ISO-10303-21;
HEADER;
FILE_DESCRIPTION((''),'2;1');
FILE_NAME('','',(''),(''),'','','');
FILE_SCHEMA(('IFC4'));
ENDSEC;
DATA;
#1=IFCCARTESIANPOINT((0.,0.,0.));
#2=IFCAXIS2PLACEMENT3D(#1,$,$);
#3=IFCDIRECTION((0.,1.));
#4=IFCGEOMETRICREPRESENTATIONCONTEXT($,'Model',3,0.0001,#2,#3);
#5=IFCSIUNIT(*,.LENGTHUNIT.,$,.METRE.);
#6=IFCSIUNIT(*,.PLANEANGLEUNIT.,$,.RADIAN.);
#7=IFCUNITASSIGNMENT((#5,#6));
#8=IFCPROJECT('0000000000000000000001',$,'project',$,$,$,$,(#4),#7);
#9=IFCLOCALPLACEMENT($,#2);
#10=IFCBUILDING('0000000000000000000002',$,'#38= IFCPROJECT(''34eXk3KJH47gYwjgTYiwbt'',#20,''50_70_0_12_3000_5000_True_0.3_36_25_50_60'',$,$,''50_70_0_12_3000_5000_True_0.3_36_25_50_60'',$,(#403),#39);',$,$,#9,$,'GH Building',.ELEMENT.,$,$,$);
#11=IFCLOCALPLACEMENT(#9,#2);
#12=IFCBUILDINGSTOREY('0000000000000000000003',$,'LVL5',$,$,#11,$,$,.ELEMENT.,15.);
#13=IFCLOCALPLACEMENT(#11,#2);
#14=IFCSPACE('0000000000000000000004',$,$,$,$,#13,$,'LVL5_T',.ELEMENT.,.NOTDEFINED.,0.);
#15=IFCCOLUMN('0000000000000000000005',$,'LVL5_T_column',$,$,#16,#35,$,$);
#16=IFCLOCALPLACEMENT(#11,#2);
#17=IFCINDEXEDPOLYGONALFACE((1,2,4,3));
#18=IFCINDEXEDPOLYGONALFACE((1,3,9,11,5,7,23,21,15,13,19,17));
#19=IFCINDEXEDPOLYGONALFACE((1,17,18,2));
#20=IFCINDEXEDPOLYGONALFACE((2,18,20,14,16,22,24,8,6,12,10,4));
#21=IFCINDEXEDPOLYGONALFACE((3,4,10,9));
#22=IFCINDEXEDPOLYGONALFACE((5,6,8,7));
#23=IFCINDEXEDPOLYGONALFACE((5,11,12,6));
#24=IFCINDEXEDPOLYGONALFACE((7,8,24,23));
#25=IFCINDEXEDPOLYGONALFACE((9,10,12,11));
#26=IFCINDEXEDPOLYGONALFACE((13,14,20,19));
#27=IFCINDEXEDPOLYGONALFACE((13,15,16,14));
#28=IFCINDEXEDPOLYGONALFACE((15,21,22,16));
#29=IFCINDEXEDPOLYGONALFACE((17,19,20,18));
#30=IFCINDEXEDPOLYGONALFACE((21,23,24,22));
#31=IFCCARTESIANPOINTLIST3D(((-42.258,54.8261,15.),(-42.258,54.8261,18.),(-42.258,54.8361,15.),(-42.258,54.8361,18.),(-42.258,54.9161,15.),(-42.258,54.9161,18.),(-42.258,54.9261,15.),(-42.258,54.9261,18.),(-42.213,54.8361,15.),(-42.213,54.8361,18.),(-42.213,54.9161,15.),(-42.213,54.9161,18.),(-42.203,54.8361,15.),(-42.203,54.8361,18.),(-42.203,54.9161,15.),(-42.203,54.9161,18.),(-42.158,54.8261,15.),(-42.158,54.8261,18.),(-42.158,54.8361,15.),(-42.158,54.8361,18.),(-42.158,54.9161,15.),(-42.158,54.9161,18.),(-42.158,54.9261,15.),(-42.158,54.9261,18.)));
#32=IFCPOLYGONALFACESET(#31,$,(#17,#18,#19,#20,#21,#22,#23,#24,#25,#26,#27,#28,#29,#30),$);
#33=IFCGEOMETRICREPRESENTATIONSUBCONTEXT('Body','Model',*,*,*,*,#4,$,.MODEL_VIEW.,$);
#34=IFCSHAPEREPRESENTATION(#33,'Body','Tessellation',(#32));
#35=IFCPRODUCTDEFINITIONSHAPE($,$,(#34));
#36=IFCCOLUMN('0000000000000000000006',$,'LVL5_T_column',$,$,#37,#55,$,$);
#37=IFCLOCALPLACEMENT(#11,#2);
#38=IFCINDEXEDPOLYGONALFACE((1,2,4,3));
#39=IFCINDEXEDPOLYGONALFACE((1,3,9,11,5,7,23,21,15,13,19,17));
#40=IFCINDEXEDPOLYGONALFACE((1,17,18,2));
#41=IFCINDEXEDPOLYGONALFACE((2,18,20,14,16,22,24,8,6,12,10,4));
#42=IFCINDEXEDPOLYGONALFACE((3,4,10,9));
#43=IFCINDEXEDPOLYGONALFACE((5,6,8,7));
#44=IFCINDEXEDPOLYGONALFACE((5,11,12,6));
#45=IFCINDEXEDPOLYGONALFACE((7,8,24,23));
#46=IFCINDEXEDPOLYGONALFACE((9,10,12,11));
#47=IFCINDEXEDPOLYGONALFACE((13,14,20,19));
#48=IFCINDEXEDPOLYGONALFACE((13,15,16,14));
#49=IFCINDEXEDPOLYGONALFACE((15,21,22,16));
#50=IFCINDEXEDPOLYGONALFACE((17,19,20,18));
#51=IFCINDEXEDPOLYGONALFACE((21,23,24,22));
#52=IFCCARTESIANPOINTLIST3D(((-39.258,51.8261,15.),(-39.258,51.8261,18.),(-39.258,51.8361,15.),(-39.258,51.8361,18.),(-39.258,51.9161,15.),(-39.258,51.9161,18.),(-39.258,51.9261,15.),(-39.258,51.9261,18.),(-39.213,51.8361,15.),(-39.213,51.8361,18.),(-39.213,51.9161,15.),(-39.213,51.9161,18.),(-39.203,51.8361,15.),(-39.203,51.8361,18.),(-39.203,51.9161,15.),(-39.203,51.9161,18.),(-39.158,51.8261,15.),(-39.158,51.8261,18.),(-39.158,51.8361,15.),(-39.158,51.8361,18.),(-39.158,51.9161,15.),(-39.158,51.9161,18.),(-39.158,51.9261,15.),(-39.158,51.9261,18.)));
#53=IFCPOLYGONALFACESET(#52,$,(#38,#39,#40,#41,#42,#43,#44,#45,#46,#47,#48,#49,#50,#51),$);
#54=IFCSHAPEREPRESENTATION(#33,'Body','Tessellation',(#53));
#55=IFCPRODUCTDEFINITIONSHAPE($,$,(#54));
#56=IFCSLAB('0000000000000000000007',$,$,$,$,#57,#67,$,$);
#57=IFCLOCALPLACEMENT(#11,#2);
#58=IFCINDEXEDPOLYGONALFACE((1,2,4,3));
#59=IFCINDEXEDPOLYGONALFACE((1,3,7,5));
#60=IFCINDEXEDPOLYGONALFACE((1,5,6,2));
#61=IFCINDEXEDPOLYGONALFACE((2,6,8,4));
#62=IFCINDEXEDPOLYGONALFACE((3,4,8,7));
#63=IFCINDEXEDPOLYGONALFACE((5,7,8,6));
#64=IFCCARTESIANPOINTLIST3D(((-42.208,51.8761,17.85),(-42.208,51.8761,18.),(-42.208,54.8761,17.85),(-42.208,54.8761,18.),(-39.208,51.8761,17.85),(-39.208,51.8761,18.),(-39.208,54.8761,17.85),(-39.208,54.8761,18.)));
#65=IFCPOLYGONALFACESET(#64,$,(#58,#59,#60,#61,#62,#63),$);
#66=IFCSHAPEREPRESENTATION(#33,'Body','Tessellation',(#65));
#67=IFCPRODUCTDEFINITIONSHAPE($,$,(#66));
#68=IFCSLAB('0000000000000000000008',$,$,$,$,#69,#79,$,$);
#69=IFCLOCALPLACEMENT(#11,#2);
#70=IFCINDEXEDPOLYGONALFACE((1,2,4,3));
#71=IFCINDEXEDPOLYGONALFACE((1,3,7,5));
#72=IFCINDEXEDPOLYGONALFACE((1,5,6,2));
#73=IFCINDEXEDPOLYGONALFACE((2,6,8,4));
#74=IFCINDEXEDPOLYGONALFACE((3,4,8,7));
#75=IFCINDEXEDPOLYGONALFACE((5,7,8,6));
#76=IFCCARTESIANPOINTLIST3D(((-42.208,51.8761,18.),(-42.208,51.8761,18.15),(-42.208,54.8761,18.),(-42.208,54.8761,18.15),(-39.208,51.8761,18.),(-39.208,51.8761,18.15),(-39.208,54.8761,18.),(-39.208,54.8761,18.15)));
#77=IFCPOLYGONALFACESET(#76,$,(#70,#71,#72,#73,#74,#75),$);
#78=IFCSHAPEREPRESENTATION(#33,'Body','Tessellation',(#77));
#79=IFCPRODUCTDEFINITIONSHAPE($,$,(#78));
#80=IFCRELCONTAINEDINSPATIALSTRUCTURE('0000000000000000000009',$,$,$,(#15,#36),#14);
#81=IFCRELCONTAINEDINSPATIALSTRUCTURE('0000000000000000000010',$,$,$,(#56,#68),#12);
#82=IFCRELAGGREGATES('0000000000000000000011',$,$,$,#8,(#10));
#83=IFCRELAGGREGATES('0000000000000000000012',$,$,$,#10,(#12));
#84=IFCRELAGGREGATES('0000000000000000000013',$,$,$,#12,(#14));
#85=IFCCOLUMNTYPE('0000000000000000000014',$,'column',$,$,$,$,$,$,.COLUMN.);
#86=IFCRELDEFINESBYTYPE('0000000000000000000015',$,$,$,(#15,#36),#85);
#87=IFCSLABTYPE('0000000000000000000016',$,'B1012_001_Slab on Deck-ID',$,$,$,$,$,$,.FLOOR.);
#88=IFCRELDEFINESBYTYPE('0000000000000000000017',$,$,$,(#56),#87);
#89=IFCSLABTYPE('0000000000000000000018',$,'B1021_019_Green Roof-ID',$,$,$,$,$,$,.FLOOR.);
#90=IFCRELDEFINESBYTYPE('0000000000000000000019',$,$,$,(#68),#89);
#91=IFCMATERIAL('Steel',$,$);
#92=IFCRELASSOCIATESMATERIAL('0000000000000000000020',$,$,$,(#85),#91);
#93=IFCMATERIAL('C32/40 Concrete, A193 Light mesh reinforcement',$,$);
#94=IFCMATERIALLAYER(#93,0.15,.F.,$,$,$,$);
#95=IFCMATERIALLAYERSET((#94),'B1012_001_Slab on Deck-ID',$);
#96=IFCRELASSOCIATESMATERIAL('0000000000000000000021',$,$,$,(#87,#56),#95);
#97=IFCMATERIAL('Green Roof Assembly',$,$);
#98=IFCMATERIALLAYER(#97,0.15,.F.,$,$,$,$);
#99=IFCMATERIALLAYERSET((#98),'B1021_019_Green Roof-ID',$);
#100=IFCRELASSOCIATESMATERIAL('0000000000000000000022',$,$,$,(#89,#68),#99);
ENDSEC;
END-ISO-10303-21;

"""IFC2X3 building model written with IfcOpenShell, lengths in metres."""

from ifc_helpers import new_model, si_unit, direction, frame, origin, origin_2d, place, context, subcontext, project, spatial, polyline, i_section, outline, extrude, material, layer, layer_set, layer_usage, type_object, element, save


model = new_model("IFC2X3")

# Units and contexts
model_context = context("Model", 3, precision=0.0001, world=origin(), true_north=direction((0.0, 1.0)))
body_context = subcontext(model_context, "Body", "Model", "MODEL_VIEW")
ifc_project = project(units=[si_unit("LENGTHUNIT", "METRE"), si_unit("PLANEANGLEUNIT", "RADIAN")], contexts=[model_context])

# Building, storey, space
building_placement = place(None, origin())
building = spatial("IfcBuilding", under=ifc_project, at=building_placement, Name="#38= IFCPROJECT('34eXk3KJH47gYwjgTYiwbt',#20,'50_70_0_12_3000_5000_True_0.3_36_25_50_60',$,$,'50_70_0_12_3000_5000_True_0.3_36_25_50_60',$,(#403),#39);", LongName="GH Building", CompositionType="ELEMENT")
storey_placement = place(building_placement, origin())
storey = spatial("IfcBuildingStorey", under=building, at=storey_placement, Name="LVL5", CompositionType="ELEMENT", Elevation=15.0)
space_1_placement = place(storey_placement, origin())
space_1 = spatial("IfcSpace", under=storey, at=space_1_placement, LongName="LVL5_T", CompositionType="ELEMENT", InteriorOrExteriorSpace="NOTDEFINED", ElevationWithFlooring=0.0)

# Columns
ifc_material_1 = material(Name="Steel")
column_type = type_object("IfcColumnType", Name="column", PredefinedType="COLUMN", material=ifc_material_1)
for number, where, name in (
    (1, (-42.208, 54.8761, 15.0), "LVL5_T_column"),
    (2, (-39.208, 51.8761, 15.0), "LVL5_T_column"),
):
    element("IfcColumn", number, at=place(space_1_placement, frame(where)), inside=space_1, type_object=column_type, Name=name, context=body_context, shape_type="SweptSolid", body=[
        extrude(i_section(OverallWidth=0.1, OverallDepth=0.1, WebThickness=0.01, FlangeThickness=0.01, at=origin_2d()), origin(), (0.0, 0.0, 1.0), 3.0),
    ])

# Slabs
ifc_material_2 = material(Name="C32/40 Concrete, A193 Light mesh reinforcement")
ifc_layer_1 = layer(ifc_material_2, 0.15, ventilated=False)
ifc_layer_set_1 = layer_set([ifc_layer_1], Name="B1012_001_Slab on Deck-ID")
ifc_layer_usage_1 = layer_usage(ifc_layer_set_1, "AXIS3", "NEGATIVE", -0.15)
slab_type_1 = type_object("IfcSlabType", Name="B1012_001_Slab on Deck-ID", PredefinedType="FLOOR", material=ifc_layer_set_1)
slab_1_placement = place(storey_placement, frame((-40.708, 53.3761, 17.85)))
element("IfcSlab", 3, at=slab_1_placement, inside=storey, type_object=slab_type_1, material=ifc_layer_usage_1, context=body_context, shape_type="SweptSolid", body=[
    extrude(outline(polyline([(-1.5, 1.5), (1.5, 1.5), (1.5, -1.5), (-1.5, -1.5), (-1.5, 1.5)])), origin(), (0.0, 0.0, 1.0), 0.15),
])
ifc_material_3 = material(Name="Green Roof Assembly")
ifc_layer_2 = layer(ifc_material_3, 0.15, ventilated=False)
ifc_layer_set_2 = layer_set([ifc_layer_2], Name="B1021_019_Green Roof-ID")
ifc_layer_usage_2 = layer_usage(ifc_layer_set_2, "AXIS3", "NEGATIVE", -0.15)
slab_type_2 = type_object("IfcSlabType", Name="B1021_019_Green Roof-ID", PredefinedType="FLOOR", material=ifc_layer_set_2)
slab_2_placement = place(storey_placement, frame((-40.708, 53.3761, 18.0)))
element("IfcSlab", 4, at=slab_2_placement, inside=storey, type_object=slab_type_2, material=ifc_layer_usage_2, context=body_context, shape_type="SweptSolid", body=[
    extrude(outline(polyline([(-1.5, 1.5), (1.5, 1.5), (1.5, -1.5), (-1.5, -1.5), (-1.5, 1.5)])), origin(), (0.0, 0.0, 1.0), 0.15),
])

save(model, "model.ifc")
